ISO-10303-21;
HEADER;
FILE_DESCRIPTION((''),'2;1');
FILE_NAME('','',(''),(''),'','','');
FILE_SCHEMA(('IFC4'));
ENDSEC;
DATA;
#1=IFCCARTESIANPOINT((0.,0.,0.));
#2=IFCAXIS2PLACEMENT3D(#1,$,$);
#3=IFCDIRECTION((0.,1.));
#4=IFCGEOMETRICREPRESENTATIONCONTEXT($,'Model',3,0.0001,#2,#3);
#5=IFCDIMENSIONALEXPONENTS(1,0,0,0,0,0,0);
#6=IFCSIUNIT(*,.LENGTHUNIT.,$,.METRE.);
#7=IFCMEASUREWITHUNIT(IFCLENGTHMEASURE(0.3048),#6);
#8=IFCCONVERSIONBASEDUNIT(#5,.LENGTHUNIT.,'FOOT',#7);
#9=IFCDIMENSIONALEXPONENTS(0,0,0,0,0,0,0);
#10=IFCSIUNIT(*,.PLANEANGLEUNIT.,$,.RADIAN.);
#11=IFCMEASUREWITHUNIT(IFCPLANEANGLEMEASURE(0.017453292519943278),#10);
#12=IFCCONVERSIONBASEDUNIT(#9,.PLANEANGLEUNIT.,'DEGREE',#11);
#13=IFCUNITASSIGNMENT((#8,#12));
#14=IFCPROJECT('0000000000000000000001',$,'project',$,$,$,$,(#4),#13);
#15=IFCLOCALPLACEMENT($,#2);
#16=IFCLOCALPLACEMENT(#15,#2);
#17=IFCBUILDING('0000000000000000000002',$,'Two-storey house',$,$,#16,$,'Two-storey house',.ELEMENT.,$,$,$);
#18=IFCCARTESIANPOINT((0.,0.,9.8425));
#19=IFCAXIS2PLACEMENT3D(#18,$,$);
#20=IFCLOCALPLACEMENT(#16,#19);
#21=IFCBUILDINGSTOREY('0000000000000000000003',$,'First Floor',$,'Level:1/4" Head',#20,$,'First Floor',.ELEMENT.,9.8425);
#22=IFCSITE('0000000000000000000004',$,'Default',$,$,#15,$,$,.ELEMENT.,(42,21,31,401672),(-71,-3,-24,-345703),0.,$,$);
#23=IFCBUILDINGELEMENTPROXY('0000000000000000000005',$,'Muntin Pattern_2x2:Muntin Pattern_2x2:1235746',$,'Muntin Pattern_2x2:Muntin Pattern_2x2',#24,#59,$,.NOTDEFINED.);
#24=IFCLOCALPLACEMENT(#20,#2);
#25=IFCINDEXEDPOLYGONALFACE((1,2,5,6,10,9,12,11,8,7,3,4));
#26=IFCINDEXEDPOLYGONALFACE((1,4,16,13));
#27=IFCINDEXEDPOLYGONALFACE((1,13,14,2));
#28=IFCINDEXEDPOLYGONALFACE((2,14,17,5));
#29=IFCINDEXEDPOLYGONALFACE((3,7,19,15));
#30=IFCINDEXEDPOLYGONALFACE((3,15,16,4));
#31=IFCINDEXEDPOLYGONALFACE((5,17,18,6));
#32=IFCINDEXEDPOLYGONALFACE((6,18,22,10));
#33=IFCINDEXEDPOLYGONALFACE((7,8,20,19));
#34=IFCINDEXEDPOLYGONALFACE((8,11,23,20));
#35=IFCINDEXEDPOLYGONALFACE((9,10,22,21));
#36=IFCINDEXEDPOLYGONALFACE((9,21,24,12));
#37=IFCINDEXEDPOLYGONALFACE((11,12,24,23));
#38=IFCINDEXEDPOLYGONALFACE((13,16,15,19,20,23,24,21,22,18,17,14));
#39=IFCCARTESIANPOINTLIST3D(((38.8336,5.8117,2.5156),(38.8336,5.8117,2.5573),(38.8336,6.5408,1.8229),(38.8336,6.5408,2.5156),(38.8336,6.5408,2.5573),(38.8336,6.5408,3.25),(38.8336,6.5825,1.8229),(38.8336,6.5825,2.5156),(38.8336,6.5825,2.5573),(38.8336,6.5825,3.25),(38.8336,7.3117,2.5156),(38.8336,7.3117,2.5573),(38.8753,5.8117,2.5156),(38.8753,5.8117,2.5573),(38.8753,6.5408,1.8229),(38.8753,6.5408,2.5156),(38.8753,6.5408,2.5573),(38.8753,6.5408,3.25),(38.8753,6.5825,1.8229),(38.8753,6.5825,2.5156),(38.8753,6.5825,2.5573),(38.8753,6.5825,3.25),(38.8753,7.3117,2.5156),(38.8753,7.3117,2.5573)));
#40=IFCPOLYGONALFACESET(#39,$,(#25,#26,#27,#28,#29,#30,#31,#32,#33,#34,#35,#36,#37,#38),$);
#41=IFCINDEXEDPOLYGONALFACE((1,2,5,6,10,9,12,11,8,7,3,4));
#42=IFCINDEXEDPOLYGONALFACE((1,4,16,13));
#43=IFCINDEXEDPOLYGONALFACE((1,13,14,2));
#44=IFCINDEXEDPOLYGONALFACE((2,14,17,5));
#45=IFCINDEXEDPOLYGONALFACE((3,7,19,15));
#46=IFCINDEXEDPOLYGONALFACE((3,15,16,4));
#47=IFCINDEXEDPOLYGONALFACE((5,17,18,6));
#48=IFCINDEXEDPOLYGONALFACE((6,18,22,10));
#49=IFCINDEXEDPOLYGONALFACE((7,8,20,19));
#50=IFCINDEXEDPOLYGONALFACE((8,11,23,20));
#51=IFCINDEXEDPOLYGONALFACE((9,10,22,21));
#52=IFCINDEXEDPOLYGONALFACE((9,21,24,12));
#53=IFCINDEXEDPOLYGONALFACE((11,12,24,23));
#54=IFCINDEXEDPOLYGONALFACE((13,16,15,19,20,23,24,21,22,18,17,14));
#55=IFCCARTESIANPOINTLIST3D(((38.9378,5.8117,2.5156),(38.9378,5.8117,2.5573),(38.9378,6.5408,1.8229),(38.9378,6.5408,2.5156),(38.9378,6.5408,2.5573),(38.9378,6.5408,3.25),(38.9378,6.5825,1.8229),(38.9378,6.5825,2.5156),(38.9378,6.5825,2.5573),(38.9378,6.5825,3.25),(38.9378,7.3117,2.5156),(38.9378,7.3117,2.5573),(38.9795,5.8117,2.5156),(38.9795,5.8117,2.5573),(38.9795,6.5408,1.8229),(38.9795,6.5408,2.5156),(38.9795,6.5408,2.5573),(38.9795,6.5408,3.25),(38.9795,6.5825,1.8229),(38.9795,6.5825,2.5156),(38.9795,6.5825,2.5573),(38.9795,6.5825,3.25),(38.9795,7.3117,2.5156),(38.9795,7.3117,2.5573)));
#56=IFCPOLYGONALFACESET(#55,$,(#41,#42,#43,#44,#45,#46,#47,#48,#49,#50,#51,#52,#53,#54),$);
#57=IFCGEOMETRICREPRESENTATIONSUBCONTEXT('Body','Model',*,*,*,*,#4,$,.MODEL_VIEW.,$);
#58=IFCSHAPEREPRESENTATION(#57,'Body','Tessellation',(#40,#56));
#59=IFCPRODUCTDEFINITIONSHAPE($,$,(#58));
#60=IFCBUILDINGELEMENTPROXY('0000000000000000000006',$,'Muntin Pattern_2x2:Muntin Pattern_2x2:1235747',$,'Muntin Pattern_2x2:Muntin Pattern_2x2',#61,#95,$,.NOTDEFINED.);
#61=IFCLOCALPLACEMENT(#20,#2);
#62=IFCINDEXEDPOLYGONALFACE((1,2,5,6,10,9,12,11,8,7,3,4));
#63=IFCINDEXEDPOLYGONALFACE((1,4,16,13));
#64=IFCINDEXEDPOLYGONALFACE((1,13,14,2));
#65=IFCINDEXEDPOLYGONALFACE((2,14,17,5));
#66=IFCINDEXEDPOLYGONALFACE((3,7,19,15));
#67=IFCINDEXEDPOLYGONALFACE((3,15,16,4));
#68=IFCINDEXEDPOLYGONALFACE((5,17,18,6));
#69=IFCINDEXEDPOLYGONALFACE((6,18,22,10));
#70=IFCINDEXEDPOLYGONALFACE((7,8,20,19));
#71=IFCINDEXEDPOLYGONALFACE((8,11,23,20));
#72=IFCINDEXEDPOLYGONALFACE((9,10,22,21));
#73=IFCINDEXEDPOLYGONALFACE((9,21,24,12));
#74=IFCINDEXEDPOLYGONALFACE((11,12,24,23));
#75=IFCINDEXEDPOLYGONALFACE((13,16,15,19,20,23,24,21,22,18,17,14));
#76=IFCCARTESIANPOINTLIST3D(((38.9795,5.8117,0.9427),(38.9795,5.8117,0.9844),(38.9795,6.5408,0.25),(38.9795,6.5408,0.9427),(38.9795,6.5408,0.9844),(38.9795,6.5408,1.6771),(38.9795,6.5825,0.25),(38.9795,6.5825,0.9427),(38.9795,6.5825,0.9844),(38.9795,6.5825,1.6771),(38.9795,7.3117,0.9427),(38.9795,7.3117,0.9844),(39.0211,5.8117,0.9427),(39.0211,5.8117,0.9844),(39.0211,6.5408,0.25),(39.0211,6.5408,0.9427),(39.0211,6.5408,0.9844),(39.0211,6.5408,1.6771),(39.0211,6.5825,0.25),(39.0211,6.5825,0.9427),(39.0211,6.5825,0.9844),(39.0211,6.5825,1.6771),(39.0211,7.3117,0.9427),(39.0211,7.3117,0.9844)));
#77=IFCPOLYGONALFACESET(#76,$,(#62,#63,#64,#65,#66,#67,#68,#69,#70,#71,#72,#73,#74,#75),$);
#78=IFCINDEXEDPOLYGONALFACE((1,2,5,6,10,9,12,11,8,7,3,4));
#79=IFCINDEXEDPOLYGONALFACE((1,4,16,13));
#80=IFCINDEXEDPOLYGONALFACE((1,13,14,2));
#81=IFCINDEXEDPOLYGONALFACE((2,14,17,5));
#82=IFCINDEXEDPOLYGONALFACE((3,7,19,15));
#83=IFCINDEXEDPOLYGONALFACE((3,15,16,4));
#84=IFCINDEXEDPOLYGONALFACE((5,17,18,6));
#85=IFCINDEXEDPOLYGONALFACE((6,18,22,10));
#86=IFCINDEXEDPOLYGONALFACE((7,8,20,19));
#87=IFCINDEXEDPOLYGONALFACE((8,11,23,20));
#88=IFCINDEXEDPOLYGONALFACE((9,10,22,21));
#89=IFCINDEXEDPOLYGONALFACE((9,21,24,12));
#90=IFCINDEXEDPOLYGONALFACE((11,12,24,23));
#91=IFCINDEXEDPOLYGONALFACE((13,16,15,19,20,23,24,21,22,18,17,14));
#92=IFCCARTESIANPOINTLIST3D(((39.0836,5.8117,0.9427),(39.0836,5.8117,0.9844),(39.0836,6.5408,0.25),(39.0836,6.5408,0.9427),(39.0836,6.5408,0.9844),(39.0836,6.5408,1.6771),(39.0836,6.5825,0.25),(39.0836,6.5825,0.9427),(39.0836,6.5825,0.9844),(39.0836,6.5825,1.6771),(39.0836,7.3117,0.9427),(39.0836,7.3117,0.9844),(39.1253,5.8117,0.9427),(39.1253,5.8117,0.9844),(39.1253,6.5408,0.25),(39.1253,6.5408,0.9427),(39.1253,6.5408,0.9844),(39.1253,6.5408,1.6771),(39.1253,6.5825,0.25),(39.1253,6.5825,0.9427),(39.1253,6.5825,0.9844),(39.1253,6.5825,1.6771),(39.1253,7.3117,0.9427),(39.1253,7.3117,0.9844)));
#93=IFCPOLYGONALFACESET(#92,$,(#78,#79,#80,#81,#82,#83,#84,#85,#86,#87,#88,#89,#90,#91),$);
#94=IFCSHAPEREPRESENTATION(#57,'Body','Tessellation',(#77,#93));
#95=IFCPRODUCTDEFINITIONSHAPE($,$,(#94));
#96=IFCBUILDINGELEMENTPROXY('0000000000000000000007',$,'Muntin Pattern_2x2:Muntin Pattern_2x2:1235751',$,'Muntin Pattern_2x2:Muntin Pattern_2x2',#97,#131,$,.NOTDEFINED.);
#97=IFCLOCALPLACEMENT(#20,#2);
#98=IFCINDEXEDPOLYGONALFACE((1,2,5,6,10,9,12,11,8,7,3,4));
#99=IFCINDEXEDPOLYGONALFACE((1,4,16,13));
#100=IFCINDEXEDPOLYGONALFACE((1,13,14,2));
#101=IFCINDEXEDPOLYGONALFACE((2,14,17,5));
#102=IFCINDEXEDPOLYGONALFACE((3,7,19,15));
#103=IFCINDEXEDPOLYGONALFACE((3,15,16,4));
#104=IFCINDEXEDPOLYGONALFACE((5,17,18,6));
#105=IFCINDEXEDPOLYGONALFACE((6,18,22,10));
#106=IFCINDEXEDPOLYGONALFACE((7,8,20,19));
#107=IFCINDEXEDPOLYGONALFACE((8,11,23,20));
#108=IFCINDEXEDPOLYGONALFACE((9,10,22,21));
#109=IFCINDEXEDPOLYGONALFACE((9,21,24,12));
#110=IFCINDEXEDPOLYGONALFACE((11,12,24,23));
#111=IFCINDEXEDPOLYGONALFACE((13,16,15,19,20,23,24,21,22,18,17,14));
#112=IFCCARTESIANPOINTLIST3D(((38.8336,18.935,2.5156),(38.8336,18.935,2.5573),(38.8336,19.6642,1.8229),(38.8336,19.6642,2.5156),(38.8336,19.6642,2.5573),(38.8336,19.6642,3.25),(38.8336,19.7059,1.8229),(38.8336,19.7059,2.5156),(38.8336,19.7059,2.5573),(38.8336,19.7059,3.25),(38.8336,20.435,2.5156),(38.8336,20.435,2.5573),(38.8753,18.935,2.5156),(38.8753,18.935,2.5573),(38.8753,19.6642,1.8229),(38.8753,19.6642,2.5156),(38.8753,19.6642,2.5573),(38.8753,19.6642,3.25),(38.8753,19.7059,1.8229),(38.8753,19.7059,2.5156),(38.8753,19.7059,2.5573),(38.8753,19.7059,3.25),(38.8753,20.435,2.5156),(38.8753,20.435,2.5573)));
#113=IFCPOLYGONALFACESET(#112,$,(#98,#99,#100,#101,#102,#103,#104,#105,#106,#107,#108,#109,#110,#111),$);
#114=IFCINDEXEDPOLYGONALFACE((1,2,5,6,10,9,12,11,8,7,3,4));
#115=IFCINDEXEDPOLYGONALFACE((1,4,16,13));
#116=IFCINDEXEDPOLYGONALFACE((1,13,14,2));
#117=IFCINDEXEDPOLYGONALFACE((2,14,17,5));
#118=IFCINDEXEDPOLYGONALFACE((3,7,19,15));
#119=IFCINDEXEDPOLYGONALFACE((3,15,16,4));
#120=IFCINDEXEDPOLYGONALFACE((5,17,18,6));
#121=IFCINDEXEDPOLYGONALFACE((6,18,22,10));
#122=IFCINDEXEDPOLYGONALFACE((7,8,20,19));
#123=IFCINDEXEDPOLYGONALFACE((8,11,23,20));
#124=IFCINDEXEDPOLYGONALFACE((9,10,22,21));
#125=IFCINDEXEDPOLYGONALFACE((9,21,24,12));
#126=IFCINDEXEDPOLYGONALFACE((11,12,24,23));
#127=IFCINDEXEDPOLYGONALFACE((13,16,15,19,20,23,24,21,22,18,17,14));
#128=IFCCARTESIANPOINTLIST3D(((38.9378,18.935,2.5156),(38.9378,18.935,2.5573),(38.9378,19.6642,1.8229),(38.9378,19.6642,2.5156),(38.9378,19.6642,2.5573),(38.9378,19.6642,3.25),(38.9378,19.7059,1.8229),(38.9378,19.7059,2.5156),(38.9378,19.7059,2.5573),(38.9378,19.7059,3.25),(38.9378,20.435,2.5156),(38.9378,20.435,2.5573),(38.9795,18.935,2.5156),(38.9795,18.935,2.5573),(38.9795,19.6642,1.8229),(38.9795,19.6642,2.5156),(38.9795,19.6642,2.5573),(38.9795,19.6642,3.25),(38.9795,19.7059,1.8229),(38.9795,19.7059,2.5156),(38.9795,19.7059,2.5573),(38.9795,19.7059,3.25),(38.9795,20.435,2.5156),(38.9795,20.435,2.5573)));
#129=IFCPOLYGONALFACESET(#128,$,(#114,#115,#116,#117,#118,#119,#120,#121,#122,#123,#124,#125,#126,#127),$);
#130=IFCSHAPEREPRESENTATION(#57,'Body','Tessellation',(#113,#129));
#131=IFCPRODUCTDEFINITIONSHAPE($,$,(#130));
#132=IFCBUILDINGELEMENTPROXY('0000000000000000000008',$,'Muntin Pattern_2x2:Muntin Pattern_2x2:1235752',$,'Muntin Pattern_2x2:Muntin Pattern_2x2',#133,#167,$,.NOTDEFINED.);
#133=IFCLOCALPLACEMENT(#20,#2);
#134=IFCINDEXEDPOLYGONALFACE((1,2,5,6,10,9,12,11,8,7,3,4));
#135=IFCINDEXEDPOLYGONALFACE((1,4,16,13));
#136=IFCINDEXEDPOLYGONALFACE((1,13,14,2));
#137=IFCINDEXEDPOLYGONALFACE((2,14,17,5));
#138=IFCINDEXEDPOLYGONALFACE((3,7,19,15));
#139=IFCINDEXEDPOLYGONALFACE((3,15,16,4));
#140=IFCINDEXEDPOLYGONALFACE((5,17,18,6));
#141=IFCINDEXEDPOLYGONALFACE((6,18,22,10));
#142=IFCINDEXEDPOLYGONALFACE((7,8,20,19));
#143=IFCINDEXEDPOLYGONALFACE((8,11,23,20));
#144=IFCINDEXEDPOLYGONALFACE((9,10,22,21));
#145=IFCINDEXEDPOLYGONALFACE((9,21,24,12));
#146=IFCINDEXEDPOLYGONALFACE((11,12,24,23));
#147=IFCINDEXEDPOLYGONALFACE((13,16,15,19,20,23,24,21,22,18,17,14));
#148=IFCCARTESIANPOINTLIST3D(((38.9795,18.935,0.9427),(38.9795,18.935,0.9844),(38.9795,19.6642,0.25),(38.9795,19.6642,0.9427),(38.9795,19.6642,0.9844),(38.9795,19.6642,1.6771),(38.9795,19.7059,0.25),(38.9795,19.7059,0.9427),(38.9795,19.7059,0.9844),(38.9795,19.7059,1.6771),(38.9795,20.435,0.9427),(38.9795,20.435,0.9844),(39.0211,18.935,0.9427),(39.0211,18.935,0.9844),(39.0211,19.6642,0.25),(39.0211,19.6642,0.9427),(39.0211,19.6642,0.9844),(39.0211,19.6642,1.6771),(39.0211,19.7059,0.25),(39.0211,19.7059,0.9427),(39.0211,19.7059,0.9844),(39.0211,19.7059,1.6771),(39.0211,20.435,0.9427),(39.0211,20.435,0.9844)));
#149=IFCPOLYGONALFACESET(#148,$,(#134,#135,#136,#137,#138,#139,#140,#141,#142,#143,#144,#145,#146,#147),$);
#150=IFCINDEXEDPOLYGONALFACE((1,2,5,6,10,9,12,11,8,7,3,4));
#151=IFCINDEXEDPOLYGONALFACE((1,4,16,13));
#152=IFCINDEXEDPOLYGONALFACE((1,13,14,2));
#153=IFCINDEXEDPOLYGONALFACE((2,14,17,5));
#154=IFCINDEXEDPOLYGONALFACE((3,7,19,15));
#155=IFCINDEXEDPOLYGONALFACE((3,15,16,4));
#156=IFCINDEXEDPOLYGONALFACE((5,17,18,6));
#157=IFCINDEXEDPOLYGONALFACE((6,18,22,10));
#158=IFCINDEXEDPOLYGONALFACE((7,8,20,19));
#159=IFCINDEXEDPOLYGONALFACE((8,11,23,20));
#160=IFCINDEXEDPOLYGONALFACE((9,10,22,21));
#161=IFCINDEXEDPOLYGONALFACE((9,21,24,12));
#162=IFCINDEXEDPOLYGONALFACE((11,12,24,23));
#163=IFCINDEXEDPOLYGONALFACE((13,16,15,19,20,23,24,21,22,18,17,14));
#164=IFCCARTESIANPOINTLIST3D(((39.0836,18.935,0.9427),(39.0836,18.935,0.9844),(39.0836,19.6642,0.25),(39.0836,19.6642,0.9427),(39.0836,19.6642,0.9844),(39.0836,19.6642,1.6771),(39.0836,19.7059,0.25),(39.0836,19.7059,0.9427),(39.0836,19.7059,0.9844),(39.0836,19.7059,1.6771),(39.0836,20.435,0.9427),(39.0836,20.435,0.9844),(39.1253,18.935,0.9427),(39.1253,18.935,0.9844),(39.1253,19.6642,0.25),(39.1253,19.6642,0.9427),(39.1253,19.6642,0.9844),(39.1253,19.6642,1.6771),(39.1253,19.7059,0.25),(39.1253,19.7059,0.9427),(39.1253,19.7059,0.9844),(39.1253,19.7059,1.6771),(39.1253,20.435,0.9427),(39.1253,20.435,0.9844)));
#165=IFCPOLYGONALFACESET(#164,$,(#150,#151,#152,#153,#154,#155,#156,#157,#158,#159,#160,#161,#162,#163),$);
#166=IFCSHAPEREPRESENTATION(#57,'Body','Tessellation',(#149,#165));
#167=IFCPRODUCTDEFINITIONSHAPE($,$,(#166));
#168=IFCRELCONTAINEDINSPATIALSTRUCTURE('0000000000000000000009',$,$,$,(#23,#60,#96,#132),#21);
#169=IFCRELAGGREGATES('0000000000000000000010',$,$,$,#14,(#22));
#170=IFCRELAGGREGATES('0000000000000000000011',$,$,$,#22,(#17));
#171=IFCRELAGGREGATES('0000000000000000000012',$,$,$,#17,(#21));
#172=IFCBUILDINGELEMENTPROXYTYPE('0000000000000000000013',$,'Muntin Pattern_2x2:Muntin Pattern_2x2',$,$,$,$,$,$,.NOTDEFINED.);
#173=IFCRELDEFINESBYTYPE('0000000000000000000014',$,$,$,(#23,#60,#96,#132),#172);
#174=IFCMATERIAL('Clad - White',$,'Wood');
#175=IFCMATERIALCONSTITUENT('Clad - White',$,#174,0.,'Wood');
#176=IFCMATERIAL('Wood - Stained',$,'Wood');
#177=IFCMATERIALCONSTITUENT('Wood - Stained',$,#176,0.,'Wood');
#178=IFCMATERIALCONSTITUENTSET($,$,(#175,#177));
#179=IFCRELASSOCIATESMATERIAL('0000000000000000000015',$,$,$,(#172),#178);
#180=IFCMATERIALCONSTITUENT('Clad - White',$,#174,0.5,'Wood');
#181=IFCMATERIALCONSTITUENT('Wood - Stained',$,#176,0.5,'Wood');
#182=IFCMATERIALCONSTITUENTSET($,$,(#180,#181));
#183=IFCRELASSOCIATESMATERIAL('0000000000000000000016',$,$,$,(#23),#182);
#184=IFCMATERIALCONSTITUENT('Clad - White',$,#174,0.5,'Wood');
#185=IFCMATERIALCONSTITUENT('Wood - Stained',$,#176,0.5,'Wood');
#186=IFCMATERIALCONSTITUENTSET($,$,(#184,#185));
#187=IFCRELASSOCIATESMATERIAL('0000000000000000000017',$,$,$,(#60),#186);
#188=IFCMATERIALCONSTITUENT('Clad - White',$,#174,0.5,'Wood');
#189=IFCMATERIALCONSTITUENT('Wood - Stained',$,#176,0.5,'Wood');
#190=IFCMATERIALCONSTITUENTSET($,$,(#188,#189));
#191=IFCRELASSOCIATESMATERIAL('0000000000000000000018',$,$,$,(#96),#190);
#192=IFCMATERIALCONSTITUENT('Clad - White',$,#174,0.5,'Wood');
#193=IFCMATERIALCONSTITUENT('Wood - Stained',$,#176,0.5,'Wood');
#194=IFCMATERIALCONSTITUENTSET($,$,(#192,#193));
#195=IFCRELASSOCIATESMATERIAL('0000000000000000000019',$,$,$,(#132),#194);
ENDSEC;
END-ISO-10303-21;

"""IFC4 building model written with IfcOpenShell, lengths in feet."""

from ifc_helpers import new_model, entity, si_unit, converted_unit, direction, frame, origin, place, context, subcontext, project, spatial, indexed_curve, outline, extrude, source, transform, mapped, material, constituent, constituent_set, type_object, type_shapes, element, save


model = new_model("IFC4")

# Units and contexts
model_context = context("Model", 3, precision=0.0001, world=origin(), true_north=direction((0.0, 1.0)))
body_context = subcontext(model_context, "Body", "Model", "MODEL_VIEW")
ifc_project = project(units=[converted_unit("LENGTHUNIT", "FOOT", entity("IfcLengthMeasure", 0.3048), si_unit("LENGTHUNIT", "METRE"), dimensions=[1, 0, 0, 0, 0, 0, 0]), converted_unit("PLANEANGLEUNIT", "DEGREE", entity("IfcPlaneAngleMeasure", 0.017453292519943278), si_unit("PLANEANGLEUNIT", "RADIAN"), dimensions=[0, 0, 0, 0, 0, 0, 0])], contexts=[model_context])

# Site, building, storey
site_placement = place(None, origin())
site = spatial("IfcSite", under=ifc_project, at=site_placement, Name="Default", CompositionType="ELEMENT", RefLatitude=(42, 21, 31, 401672), RefLongitude=(-71, -3, -24, -345703), RefElevation=0.0)
building_placement = place(site_placement, origin())
building = spatial("IfcBuilding", under=site, at=building_placement, Name="Two-storey house", LongName="Two-storey house", CompositionType="ELEMENT")
storey_placement = place(building_placement, frame((0.0, 0.0, 9.8425)))
storey = spatial("IfcBuildingStorey", under=building, at=storey_placement, Name="First Floor", ObjectType="Level:1/4\" Head", LongName="First Floor", CompositionType="ELEMENT", Elevation=9.8425)

# Shared definitions
ifc_material_1 = material(Name="Wood - Stained", Category="Wood")

# Building element proxies
ifc_material_2 = material(Name="Clad - White", Category="Wood")
ifc_constituent_1 = constituent(ifc_material_2, Name="Clad - White", Category="Wood", fraction=0.5)
ifc_constituent_2 = constituent(ifc_material_1, Name="Wood - Stained", Category="Wood", fraction=0.5)
ifc_constituent_set_1 = constituent_set(constituents=[ifc_constituent_1, ifc_constituent_2])
ifc_constituent_3 = constituent(ifc_material_2, Name="Clad - White", Category="Wood", fraction=0.0)
ifc_constituent_4 = constituent(ifc_material_1, Name="Wood - Stained", Category="Wood", fraction=0.0)
ifc_constituent_set_2 = constituent_set(constituents=[ifc_constituent_3, ifc_constituent_4])
building_element_proxy_type_1 = type_object("IfcBuildingElementProxyType", Name="Muntin Pattern_2x2:Muntin Pattern_2x2", PredefinedType="NOTDEFINED", material=ifc_constituent_set_2)
shared_shape_1 = source(origin(), body_context, "Body", "SweptSolid", [
    extrude(outline(indexed_curve([(0.0208, -0.0208), (0.7135, -0.0208), (0.7135, 0.0208), (0.0208, 0.0208), (0.0208, 0.75), (-0.0208, 0.75), (-0.0208, 0.0208), (-0.7135, 0.0208), (-0.7135, -0.0208), (-0.0208, -0.0208), (-0.0208, -0.75), (0.0208, -0.75), (0.0208, -0.0208)], self_intersect=False)), frame((0.0, 0.0312, 0.7135), z_axis=(0.0, 1.0, 0.0), x_axis=(0.0, 0.0, 1.0)), (0.0, 0.0, 1.0), 0.0417),
    extrude(outline(indexed_curve([(0.0208, -0.0208), (0.7135, -0.0208), (0.7135, 0.0208), (0.0208, 0.0208), (0.0208, 0.75), (-0.0208, 0.75), (-0.0208, 0.0208), (-0.7135, 0.0208), (-0.7135, -0.0208), (-0.0208, -0.0208), (-0.0208, -0.75), (0.0208, -0.75), (0.0208, -0.0208)], self_intersect=False)), frame((0.0, -0.0729, 0.7135), z_axis=(0.0, 1.0, 0.0), x_axis=(0.0, 0.0, 1.0)), (0.0, 0.0, 1.0), 0.0417),
])
type_shapes(building_element_proxy_type_1, [shared_shape_1])
proxy_1_placement = place(storey_placement, frame((38.9065, 6.5617, 1.8229), z_axis=(0.0, 0.0, 1.0), x_axis=(0.0, 1.0, 0.0)))
element("IfcBuildingElementProxy", 1, at=proxy_1_placement, inside=storey, type_object=building_element_proxy_type_1, material=ifc_constituent_set_1, Name="Muntin Pattern_2x2:Muntin Pattern_2x2:1235746", ObjectType="Muntin Pattern_2x2:Muntin Pattern_2x2", PredefinedType="NOTDEFINED", context=body_context, shape_type="MappedRepresentation", body=[
    mapped(shared_shape_1, transform((0.0, 0.0, 0.0), scale=1.0)),
])
ifc_constituent_5 = constituent(ifc_material_2, Name="Clad - White", Category="Wood", fraction=0.5)
ifc_constituent_6 = constituent(ifc_material_1, Name="Wood - Stained", Category="Wood", fraction=0.5)
ifc_constituent_set_3 = constituent_set(constituents=[ifc_constituent_5, ifc_constituent_6])
proxy_2_placement = place(storey_placement, frame((39.0524, 6.5617, 0.25), z_axis=(0.0, 0.0, 1.0), x_axis=(0.0, 1.0, 0.0)))
element("IfcBuildingElementProxy", 2, at=proxy_2_placement, inside=storey, type_object=building_element_proxy_type_1, material=ifc_constituent_set_3, Name="Muntin Pattern_2x2:Muntin Pattern_2x2:1235747", ObjectType="Muntin Pattern_2x2:Muntin Pattern_2x2", PredefinedType="NOTDEFINED", context=body_context, shape_type="MappedRepresentation", body=[
    mapped(shared_shape_1, transform((0.0, 0.0, 0.0), scale=1.0)),
])
ifc_constituent_7 = constituent(ifc_material_2, Name="Clad - White", Category="Wood", fraction=0.5)
ifc_constituent_8 = constituent(ifc_material_1, Name="Wood - Stained", Category="Wood", fraction=0.5)
ifc_constituent_set_4 = constituent_set(constituents=[ifc_constituent_7, ifc_constituent_8])
proxy_3_placement = place(storey_placement, frame((38.9065, 19.685, 1.8229), z_axis=(0.0, 0.0, 1.0), x_axis=(0.0, 1.0, 0.0)))
element("IfcBuildingElementProxy", 3, at=proxy_3_placement, inside=storey, type_object=building_element_proxy_type_1, material=ifc_constituent_set_4, Name="Muntin Pattern_2x2:Muntin Pattern_2x2:1235751", ObjectType="Muntin Pattern_2x2:Muntin Pattern_2x2", PredefinedType="NOTDEFINED", context=body_context, shape_type="MappedRepresentation", body=[
    mapped(shared_shape_1, transform((0.0, 0.0, 0.0), scale=1.0)),
])
ifc_constituent_9 = constituent(ifc_material_2, Name="Clad - White", Category="Wood", fraction=0.5)
ifc_constituent_10 = constituent(ifc_material_1, Name="Wood - Stained", Category="Wood", fraction=0.5)
ifc_constituent_set_5 = constituent_set(constituents=[ifc_constituent_9, ifc_constituent_10])
proxy_4_placement = place(storey_placement, frame((39.0524, 19.685, 0.25), z_axis=(0.0, 0.0, 1.0), x_axis=(0.0, 1.0, 0.0)))
element("IfcBuildingElementProxy", 4, at=proxy_4_placement, inside=storey, type_object=building_element_proxy_type_1, material=ifc_constituent_set_5, Name="Muntin Pattern_2x2:Muntin Pattern_2x2:1235752", ObjectType="Muntin Pattern_2x2:Muntin Pattern_2x2", PredefinedType="NOTDEFINED", context=body_context, shape_type="MappedRepresentation", body=[
    mapped(shared_shape_1, transform((0.0, 0.0, 0.0), scale=1.0)),
])

save(model, "model.ifc")
